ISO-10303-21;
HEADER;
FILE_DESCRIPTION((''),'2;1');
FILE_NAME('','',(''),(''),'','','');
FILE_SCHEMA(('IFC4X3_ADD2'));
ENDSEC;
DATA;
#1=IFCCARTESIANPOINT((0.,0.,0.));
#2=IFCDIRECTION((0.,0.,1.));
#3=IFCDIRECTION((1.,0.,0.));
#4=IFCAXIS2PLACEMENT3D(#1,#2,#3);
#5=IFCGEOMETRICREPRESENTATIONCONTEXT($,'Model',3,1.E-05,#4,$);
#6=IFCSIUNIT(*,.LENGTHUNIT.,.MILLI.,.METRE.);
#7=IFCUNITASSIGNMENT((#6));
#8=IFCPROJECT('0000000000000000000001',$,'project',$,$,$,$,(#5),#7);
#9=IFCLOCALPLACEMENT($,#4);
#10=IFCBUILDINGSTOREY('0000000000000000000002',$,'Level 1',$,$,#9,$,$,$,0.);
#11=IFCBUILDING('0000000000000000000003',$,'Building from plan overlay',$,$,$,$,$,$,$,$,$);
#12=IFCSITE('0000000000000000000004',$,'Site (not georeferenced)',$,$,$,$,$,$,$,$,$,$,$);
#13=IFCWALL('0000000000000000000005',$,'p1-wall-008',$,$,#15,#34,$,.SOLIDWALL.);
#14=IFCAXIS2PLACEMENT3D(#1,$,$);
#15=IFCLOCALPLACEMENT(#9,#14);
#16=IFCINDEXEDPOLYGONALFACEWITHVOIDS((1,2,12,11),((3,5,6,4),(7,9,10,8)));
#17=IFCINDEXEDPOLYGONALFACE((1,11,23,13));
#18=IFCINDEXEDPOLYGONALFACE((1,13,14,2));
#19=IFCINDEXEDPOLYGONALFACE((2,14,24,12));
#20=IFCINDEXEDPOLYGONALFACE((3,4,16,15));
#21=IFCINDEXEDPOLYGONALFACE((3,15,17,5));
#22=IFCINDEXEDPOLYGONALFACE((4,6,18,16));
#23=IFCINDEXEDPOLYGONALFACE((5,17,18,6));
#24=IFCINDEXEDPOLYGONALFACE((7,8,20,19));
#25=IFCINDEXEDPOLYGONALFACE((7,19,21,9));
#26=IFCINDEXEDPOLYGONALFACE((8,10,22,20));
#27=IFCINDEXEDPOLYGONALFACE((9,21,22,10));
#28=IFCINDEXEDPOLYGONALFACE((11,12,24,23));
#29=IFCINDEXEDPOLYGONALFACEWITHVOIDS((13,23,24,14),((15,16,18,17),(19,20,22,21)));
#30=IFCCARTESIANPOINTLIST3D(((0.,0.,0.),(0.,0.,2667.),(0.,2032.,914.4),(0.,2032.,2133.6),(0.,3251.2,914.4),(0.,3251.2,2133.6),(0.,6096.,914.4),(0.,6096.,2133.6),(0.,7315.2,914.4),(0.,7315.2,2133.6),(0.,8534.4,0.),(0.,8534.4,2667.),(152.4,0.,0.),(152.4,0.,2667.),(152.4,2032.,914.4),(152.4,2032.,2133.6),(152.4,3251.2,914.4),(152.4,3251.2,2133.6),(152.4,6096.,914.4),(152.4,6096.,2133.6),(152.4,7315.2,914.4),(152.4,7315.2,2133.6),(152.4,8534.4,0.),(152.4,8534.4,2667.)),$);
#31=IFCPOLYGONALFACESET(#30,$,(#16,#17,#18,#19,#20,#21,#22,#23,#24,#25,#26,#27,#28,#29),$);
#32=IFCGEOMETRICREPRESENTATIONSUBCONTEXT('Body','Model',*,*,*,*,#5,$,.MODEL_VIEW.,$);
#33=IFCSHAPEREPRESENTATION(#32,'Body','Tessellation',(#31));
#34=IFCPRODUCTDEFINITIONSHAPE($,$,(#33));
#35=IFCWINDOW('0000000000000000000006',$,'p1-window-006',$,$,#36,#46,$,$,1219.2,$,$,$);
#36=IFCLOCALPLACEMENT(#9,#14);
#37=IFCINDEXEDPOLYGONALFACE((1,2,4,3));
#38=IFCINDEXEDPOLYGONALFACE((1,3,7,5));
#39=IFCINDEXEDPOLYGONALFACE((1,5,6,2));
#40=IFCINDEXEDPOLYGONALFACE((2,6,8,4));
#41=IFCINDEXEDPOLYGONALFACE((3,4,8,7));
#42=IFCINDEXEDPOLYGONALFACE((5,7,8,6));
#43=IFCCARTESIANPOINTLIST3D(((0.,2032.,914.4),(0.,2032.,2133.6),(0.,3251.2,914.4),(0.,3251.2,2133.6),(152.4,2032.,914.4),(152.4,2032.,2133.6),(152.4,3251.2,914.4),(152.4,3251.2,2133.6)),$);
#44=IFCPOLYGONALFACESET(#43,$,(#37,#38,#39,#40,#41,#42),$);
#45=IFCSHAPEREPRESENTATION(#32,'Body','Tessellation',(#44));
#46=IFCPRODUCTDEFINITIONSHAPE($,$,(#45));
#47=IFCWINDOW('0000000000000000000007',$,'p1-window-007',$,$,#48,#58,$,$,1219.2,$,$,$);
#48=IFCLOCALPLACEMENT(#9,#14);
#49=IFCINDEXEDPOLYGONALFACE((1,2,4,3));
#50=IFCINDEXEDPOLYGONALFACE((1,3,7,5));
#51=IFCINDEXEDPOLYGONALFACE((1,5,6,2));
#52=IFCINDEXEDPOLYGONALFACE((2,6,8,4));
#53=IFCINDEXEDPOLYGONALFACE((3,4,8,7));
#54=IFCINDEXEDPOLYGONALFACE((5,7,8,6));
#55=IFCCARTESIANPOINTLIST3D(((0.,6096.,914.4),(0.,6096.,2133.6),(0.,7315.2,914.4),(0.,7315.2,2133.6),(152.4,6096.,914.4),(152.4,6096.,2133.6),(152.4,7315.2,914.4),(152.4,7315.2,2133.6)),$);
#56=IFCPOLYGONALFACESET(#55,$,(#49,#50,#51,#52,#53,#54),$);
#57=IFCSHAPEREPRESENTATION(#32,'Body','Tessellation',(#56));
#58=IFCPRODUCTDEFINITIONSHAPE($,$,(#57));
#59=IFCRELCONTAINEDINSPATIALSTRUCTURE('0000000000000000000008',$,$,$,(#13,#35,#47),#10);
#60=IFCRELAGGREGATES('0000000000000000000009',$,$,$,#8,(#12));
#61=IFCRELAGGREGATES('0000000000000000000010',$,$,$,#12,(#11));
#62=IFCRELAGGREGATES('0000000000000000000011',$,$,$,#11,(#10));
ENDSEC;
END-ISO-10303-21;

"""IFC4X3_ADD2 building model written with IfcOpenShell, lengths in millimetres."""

from ifc_helpers import new_model, si_unit, frame, origin, origin_with_axes, place, context, subcontext, project, spatial, polyline, outline, extrude, element, fill, save


model = new_model("IFC4X3_ADD2")

# Units and contexts
model_context = context("Model", 3, precision=1e-05, world=origin_with_axes())
body_context = subcontext(model_context, "Body", "Model", "MODEL_VIEW")
ifc_project = project(units=[si_unit("LENGTHUNIT", "METRE", prefix="MILLI")], contexts=[model_context])

# Site, building, storey
site = spatial("IfcSite", under=ifc_project, Name="Site (not georeferenced)")
building = spatial("IfcBuilding", under=site, Name="Building from plan overlay")
storey_placement = place(None, origin_with_axes())
storey = spatial("IfcBuildingStorey", under=building, at=storey_placement, Name="Level 1", Elevation=0.0)

# Wall, openings, windows
wall_1_placement = place(storey_placement, origin_with_axes())
wall_1 = element("IfcWall", 1, at=wall_1_placement, inside=storey, Name="p1-wall-008", PredefinedType="SOLIDWALL", context=body_context, shape_type="SweptSolid", body=[
    extrude(outline(polyline([(152.4, 0.0), (152.4, 8534.4), (0.0, 8534.4), (0.0, 0.0), (152.4, 0.0)])), origin(), (0.0, 0.0, 1.0), 2667.0),
])
opening_1_placement = place(wall_1_placement, origin_with_axes())
opening_1 = element("IfcOpeningElement", 2, at=opening_1_placement, cuts=wall_1, context=body_context, shape_type="SweptSolid", body=[
    extrude(outline(polyline([(152.4, 2032.0), (152.4, 3251.2), (0.0, 3251.2), (0.0, 2032.0), (152.4, 2032.0)])), frame((0.0, 0.0, 914.4)), (0.0, 0.0, 1.0), 1219.2),
])
opening_2_placement = place(wall_1_placement, origin_with_axes())
opening_2 = element("IfcOpeningElement", 3, at=opening_2_placement, cuts=wall_1, context=body_context, shape_type="SweptSolid", body=[
    extrude(outline(polyline([(152.4, 6096.0), (152.4, 7315.2), (0.0, 7315.2), (0.0, 6096.0), (152.4, 6096.0)])), frame((0.0, 0.0, 914.4)), (0.0, 0.0, 1.0), 1219.2),
])
window_1_placement = place(storey_placement, origin_with_axes())
window_1 = element("IfcWindow", 4, at=window_1_placement, inside=storey, Name="p1-window-006", OverallWidth=1219.2, context=body_context, shape_type="SweptSolid", body=[
    extrude(outline(polyline([(152.4, 2032.0), (152.4, 3251.2), (0.0, 3251.2), (0.0, 2032.0), (152.4, 2032.0)])), frame((0.0, 0.0, 914.4)), (0.0, 0.0, 1.0), 1219.2),
])
fill(opening_1, window_1)
window_2_placement = place(storey_placement, origin_with_axes())
window_2 = element("IfcWindow", 5, at=window_2_placement, inside=storey, Name="p1-window-007", OverallWidth=1219.2, context=body_context, shape_type="SweptSolid", body=[
    extrude(outline(polyline([(152.4, 6096.0), (152.4, 7315.2), (0.0, 7315.2), (0.0, 6096.0), (152.4, 6096.0)])), frame((0.0, 0.0, 914.4)), (0.0, 0.0, 1.0), 1219.2),
])
fill(opening_2, window_2)

save(model, "model.ifc")
